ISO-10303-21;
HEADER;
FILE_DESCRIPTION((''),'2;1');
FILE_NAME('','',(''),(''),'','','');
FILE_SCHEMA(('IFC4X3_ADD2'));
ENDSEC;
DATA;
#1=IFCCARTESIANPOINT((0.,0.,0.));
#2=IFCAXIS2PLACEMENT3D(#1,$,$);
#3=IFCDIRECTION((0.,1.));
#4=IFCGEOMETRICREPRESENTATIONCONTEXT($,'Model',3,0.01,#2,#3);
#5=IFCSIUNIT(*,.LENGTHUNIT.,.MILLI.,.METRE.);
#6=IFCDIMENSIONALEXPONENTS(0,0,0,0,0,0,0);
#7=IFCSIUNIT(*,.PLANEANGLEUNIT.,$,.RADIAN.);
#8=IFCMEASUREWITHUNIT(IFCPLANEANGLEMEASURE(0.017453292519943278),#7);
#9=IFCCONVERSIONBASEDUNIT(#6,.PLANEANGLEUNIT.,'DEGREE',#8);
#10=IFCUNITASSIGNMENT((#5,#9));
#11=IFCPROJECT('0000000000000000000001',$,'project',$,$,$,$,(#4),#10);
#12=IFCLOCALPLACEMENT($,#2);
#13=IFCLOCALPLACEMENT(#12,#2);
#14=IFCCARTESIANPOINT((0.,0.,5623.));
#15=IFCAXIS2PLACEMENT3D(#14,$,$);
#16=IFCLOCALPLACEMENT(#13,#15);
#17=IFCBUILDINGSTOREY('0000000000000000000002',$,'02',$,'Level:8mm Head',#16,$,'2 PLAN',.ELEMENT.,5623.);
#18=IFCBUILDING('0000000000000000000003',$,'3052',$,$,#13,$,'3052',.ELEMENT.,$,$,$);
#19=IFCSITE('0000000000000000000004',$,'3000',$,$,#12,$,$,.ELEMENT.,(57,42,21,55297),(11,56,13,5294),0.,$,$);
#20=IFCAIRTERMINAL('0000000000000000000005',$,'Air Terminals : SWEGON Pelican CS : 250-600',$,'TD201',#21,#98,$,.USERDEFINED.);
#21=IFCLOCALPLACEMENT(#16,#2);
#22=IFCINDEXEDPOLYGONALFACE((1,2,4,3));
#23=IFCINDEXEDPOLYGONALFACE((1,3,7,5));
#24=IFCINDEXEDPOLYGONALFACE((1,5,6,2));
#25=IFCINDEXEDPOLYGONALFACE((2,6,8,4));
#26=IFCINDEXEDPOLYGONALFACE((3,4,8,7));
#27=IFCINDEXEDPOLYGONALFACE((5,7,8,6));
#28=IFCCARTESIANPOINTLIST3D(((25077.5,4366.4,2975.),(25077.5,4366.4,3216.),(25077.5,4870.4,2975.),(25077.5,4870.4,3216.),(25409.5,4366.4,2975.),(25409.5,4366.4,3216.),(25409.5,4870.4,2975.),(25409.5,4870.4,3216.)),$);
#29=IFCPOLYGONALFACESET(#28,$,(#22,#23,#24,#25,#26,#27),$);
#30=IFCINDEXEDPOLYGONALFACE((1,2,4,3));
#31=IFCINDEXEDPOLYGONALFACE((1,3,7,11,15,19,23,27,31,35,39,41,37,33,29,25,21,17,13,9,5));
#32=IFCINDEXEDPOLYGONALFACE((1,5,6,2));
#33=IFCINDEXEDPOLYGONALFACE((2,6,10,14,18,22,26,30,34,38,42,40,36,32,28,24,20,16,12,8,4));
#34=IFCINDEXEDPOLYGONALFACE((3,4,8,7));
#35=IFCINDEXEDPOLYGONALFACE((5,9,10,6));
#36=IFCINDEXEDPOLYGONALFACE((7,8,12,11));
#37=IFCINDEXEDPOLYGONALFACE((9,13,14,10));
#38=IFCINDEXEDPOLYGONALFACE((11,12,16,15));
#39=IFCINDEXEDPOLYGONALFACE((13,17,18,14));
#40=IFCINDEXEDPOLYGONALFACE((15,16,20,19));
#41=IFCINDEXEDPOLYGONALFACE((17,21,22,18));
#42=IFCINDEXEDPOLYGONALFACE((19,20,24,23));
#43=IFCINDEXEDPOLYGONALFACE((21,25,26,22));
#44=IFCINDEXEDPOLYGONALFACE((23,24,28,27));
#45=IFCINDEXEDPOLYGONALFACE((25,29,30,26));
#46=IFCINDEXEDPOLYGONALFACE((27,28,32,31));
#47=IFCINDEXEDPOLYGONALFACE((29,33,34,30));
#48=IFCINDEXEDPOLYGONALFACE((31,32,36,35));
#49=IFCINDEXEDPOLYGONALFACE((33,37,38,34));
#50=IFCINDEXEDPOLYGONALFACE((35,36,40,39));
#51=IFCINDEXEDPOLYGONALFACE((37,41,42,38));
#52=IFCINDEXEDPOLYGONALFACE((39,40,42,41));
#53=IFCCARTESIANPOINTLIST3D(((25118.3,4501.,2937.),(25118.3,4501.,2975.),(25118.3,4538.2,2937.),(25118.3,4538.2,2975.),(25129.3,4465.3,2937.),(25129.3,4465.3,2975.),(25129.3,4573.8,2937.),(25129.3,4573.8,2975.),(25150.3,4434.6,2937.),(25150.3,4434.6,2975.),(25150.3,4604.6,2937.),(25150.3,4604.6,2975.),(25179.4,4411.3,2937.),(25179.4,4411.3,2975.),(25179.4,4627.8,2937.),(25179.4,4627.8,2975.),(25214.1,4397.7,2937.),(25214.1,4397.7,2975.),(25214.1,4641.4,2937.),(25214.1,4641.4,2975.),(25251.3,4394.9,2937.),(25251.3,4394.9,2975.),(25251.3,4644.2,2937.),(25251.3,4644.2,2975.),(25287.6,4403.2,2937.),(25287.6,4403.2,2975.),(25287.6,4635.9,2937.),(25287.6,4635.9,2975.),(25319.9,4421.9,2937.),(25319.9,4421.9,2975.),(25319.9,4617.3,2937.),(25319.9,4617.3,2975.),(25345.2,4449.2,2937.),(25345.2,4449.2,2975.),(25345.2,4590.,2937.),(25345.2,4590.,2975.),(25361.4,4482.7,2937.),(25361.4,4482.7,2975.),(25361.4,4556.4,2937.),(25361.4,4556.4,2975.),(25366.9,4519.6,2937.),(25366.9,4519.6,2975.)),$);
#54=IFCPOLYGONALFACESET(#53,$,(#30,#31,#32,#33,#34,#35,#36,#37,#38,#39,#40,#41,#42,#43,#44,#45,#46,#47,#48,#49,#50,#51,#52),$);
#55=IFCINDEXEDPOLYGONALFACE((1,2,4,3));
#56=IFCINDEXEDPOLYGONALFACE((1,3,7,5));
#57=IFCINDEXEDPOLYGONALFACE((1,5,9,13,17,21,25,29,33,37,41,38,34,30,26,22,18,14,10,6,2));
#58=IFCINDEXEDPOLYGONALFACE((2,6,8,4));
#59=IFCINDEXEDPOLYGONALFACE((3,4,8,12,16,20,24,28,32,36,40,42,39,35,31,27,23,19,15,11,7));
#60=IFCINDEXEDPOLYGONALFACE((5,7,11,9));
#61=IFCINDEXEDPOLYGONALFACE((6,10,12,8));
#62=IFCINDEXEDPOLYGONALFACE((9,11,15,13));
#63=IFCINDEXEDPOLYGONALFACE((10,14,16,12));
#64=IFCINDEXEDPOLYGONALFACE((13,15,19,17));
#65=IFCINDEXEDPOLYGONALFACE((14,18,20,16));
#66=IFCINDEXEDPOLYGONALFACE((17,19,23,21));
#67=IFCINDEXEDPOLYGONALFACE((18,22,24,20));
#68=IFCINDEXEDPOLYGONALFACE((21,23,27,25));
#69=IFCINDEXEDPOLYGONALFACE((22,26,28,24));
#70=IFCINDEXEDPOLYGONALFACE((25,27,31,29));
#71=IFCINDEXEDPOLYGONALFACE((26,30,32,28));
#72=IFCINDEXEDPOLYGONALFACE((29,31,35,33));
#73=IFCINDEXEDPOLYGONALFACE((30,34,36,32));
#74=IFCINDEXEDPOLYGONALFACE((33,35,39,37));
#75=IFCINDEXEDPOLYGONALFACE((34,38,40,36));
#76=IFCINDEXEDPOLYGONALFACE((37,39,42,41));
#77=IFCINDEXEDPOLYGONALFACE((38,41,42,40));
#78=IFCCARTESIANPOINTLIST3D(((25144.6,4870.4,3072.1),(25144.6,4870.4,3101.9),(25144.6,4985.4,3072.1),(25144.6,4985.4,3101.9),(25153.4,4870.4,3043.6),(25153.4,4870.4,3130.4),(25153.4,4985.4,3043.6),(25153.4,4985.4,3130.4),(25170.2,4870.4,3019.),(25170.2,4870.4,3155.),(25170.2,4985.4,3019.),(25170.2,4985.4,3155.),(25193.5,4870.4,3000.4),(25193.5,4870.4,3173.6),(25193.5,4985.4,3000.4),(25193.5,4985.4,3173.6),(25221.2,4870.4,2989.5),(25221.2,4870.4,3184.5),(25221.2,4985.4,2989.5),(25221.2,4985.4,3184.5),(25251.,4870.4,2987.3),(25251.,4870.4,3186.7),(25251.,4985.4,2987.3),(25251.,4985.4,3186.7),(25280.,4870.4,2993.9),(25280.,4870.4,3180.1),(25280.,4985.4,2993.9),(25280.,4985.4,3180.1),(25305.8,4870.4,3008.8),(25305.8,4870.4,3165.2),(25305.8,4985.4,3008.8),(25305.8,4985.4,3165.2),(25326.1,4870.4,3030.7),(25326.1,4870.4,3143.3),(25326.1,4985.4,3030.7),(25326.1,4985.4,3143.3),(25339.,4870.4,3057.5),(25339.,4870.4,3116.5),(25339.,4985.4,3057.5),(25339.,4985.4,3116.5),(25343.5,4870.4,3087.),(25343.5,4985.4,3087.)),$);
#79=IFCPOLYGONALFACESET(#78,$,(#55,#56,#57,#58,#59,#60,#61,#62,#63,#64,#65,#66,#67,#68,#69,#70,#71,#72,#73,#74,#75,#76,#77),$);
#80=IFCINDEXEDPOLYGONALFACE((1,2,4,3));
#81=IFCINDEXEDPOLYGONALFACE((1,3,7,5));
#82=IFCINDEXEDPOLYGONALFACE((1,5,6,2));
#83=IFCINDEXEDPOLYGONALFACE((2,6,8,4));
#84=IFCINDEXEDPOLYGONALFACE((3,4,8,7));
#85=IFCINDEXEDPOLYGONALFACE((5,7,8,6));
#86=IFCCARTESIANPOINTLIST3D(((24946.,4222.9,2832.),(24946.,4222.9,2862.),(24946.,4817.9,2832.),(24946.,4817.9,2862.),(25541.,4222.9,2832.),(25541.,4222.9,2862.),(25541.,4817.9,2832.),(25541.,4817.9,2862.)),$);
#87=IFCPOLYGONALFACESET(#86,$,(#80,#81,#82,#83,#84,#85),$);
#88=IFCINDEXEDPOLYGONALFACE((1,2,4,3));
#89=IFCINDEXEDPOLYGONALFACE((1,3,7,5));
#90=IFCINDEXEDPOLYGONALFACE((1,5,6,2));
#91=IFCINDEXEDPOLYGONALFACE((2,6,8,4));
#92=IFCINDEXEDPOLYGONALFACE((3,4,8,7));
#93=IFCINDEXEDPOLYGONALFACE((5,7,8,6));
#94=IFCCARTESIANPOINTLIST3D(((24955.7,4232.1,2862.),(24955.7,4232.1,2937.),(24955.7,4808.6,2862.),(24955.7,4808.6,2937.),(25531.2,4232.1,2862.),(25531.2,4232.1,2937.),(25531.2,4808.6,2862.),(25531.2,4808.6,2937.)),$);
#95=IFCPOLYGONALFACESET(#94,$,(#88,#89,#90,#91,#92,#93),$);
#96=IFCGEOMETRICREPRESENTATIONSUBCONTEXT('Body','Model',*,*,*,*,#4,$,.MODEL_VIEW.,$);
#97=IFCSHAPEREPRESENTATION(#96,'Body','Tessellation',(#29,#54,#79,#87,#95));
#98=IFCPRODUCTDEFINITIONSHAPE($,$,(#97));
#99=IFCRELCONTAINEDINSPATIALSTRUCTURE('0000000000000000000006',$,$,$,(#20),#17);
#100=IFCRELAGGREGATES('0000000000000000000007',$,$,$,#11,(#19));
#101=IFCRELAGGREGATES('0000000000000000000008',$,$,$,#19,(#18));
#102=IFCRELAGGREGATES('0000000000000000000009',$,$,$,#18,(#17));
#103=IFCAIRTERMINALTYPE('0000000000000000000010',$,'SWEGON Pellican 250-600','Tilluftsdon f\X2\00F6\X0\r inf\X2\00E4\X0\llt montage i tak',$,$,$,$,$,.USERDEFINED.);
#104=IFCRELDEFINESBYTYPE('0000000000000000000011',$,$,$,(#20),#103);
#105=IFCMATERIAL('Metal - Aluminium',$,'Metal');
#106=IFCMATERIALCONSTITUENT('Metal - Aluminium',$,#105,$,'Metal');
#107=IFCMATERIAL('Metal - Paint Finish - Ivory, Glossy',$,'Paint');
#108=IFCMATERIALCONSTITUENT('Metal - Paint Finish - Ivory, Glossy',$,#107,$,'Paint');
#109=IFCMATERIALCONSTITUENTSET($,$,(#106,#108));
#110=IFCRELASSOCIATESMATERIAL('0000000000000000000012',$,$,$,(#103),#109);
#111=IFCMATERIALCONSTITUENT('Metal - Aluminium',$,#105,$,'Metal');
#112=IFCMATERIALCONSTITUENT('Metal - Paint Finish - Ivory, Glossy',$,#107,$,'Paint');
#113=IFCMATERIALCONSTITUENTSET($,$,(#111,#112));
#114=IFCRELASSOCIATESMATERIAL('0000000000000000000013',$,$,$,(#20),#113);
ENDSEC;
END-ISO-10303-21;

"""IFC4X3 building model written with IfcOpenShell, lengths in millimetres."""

from ifc_helpers import new_model, entity, si_unit, converted_unit, direction, frame, frame_2d, origin, origin_2d_with_axis, place, context, subcontext, project, spatial, rectangle, circle, extrude, source, transform, mapped, material, constituent, constituent_set, type_object, type_shapes, element, save


model = new_model("IFC4X3")

# Units and contexts
model_context = context("Model", 3, precision=0.01, world=origin(), true_north=direction((0.0, 1.0)))
body_context = subcontext(model_context, "Body", "Model", "MODEL_VIEW")
ifc_project = project(units=[si_unit("LENGTHUNIT", "METRE", prefix="MILLI"), converted_unit("PLANEANGLEUNIT", "DEGREE", entity("IfcPlaneAngleMeasure", 0.017453292519943278), si_unit("PLANEANGLEUNIT", "RADIAN"), dimensions=[0, 0, 0, 0, 0, 0, 0])], contexts=[model_context])

# Site, building, storey
site_placement = place(None, origin())
site = spatial("IfcSite", under=ifc_project, at=site_placement, Name="3000", CompositionType="ELEMENT", RefLatitude=(57, 42, 21, 55297), RefLongitude=(11, 56, 13, 5294), RefElevation=0.0)
building_placement = place(site_placement, origin())
building = spatial("IfcBuilding", under=site, at=building_placement, Name="3052", LongName="3052", CompositionType="ELEMENT")
storey_placement = place(building_placement, frame((0.0, 0.0, 5623.0)))
storey = spatial("IfcBuildingStorey", under=building, at=storey_placement, Name="02", ObjectType="Level:8mm Head", LongName="2 PLAN", CompositionType="ELEMENT", Elevation=5623.0)

# Air terminal
ifc_material_1 = material(Name="Metal - Aluminium", Category="Metal")
ifc_material_2 = material(Name="Metal - Paint Finish - Ivory, Glossy", Category="Paint")
ifc_constituent_1 = constituent(ifc_material_1, Name="Metal - Aluminium", Category="Metal")
ifc_constituent_2 = constituent(ifc_material_2, Name="Metal - Paint Finish - Ivory, Glossy", Category="Paint")
ifc_constituent_set_1 = constituent_set(constituents=[ifc_constituent_1, ifc_constituent_2])
ifc_constituent_3 = constituent(ifc_material_1, Name="Metal - Aluminium", Category="Metal")
ifc_constituent_4 = constituent(ifc_material_2, Name="Metal - Paint Finish - Ivory, Glossy", Category="Paint")
ifc_constituent_set_2 = constituent_set(constituents=[ifc_constituent_3, ifc_constituent_4])
air_terminal_type_1 = type_object("IfcAirTerminalType", Name="SWEGON Pellican 250-600", Description="Tilluftsdon för infällt montage i tak", PredefinedType="USERDEFINED", material=ifc_constituent_set_2)
shared_shape_1 = source(origin(), body_context, "Body", "SweptSolid", [
    extrude(rectangle(XDim=504.0, YDim=332.0, at=origin_2d_with_axis()), frame((0.0, -98.0, -354.0), z_axis=(0.0, 0.0, 1.0), x_axis=(0.0, 1.0, 0.0)), (0.0, 0.0, 1.0), 241.0),
    extrude(circle(Radius=125.0, at=frame_2d((0.0, 0.0), x_axis=(1.0, 0.0))), frame((-1.6, 0.8, -113.0)), (0.0, 0.0, 1.0), 38.0),
    extrude(circle(Radius=100.0, at=frame_2d((0.0, 0.0), x_axis=(1.0, 0.0))), frame((0.0, -465.0, -225.0), z_axis=(0.0, 1.0, 0.0), x_axis=(1.0, 0.0, 0.0)), (0.0, 0.0, 1.0), 115.0),
    extrude(rectangle(XDim=595.0, YDim=595.0, at=frame_2d((0.0, 0.0), x_axis=(1.0, 0.0))), frame((0.0, 0.0, 0.0), z_axis=(0.0, 0.0, 1.0), x_axis=(0.0, 1.0, 0.0)), (0.0, 0.0, 1.0), 30.0),
    extrude(rectangle(XDim=576.5, YDim=575.5, at=origin_2d_with_axis()), frame((0.0, 0.0, -75.0), z_axis=(0.0, 0.0, 1.0), x_axis=(0.0, 1.0, 0.0)), (0.0, 0.0, 1.0), 75.0),
])
type_shapes(air_terminal_type_1, [shared_shape_1])
air_terminal_1_placement = place(storey_placement, frame((25243.5, 4520.4, 2862.0), z_axis=(0.0, 0.0, -1.0), x_axis=(1.0, 0.0, 0.0)))
element("IfcAirTerminal", 1, at=air_terminal_1_placement, inside=storey, type_object=air_terminal_type_1, material=ifc_constituent_set_1, Name="Air Terminals : SWEGON Pelican CS : 250-600", ObjectType="TD201", PredefinedType="USERDEFINED", context=body_context, shape_type="MappedRepresentation", body=[
    mapped(shared_shape_1, transform((0.0, 0.0, 0.0), scale=1.0)),
])

save(model, "model.ifc")
